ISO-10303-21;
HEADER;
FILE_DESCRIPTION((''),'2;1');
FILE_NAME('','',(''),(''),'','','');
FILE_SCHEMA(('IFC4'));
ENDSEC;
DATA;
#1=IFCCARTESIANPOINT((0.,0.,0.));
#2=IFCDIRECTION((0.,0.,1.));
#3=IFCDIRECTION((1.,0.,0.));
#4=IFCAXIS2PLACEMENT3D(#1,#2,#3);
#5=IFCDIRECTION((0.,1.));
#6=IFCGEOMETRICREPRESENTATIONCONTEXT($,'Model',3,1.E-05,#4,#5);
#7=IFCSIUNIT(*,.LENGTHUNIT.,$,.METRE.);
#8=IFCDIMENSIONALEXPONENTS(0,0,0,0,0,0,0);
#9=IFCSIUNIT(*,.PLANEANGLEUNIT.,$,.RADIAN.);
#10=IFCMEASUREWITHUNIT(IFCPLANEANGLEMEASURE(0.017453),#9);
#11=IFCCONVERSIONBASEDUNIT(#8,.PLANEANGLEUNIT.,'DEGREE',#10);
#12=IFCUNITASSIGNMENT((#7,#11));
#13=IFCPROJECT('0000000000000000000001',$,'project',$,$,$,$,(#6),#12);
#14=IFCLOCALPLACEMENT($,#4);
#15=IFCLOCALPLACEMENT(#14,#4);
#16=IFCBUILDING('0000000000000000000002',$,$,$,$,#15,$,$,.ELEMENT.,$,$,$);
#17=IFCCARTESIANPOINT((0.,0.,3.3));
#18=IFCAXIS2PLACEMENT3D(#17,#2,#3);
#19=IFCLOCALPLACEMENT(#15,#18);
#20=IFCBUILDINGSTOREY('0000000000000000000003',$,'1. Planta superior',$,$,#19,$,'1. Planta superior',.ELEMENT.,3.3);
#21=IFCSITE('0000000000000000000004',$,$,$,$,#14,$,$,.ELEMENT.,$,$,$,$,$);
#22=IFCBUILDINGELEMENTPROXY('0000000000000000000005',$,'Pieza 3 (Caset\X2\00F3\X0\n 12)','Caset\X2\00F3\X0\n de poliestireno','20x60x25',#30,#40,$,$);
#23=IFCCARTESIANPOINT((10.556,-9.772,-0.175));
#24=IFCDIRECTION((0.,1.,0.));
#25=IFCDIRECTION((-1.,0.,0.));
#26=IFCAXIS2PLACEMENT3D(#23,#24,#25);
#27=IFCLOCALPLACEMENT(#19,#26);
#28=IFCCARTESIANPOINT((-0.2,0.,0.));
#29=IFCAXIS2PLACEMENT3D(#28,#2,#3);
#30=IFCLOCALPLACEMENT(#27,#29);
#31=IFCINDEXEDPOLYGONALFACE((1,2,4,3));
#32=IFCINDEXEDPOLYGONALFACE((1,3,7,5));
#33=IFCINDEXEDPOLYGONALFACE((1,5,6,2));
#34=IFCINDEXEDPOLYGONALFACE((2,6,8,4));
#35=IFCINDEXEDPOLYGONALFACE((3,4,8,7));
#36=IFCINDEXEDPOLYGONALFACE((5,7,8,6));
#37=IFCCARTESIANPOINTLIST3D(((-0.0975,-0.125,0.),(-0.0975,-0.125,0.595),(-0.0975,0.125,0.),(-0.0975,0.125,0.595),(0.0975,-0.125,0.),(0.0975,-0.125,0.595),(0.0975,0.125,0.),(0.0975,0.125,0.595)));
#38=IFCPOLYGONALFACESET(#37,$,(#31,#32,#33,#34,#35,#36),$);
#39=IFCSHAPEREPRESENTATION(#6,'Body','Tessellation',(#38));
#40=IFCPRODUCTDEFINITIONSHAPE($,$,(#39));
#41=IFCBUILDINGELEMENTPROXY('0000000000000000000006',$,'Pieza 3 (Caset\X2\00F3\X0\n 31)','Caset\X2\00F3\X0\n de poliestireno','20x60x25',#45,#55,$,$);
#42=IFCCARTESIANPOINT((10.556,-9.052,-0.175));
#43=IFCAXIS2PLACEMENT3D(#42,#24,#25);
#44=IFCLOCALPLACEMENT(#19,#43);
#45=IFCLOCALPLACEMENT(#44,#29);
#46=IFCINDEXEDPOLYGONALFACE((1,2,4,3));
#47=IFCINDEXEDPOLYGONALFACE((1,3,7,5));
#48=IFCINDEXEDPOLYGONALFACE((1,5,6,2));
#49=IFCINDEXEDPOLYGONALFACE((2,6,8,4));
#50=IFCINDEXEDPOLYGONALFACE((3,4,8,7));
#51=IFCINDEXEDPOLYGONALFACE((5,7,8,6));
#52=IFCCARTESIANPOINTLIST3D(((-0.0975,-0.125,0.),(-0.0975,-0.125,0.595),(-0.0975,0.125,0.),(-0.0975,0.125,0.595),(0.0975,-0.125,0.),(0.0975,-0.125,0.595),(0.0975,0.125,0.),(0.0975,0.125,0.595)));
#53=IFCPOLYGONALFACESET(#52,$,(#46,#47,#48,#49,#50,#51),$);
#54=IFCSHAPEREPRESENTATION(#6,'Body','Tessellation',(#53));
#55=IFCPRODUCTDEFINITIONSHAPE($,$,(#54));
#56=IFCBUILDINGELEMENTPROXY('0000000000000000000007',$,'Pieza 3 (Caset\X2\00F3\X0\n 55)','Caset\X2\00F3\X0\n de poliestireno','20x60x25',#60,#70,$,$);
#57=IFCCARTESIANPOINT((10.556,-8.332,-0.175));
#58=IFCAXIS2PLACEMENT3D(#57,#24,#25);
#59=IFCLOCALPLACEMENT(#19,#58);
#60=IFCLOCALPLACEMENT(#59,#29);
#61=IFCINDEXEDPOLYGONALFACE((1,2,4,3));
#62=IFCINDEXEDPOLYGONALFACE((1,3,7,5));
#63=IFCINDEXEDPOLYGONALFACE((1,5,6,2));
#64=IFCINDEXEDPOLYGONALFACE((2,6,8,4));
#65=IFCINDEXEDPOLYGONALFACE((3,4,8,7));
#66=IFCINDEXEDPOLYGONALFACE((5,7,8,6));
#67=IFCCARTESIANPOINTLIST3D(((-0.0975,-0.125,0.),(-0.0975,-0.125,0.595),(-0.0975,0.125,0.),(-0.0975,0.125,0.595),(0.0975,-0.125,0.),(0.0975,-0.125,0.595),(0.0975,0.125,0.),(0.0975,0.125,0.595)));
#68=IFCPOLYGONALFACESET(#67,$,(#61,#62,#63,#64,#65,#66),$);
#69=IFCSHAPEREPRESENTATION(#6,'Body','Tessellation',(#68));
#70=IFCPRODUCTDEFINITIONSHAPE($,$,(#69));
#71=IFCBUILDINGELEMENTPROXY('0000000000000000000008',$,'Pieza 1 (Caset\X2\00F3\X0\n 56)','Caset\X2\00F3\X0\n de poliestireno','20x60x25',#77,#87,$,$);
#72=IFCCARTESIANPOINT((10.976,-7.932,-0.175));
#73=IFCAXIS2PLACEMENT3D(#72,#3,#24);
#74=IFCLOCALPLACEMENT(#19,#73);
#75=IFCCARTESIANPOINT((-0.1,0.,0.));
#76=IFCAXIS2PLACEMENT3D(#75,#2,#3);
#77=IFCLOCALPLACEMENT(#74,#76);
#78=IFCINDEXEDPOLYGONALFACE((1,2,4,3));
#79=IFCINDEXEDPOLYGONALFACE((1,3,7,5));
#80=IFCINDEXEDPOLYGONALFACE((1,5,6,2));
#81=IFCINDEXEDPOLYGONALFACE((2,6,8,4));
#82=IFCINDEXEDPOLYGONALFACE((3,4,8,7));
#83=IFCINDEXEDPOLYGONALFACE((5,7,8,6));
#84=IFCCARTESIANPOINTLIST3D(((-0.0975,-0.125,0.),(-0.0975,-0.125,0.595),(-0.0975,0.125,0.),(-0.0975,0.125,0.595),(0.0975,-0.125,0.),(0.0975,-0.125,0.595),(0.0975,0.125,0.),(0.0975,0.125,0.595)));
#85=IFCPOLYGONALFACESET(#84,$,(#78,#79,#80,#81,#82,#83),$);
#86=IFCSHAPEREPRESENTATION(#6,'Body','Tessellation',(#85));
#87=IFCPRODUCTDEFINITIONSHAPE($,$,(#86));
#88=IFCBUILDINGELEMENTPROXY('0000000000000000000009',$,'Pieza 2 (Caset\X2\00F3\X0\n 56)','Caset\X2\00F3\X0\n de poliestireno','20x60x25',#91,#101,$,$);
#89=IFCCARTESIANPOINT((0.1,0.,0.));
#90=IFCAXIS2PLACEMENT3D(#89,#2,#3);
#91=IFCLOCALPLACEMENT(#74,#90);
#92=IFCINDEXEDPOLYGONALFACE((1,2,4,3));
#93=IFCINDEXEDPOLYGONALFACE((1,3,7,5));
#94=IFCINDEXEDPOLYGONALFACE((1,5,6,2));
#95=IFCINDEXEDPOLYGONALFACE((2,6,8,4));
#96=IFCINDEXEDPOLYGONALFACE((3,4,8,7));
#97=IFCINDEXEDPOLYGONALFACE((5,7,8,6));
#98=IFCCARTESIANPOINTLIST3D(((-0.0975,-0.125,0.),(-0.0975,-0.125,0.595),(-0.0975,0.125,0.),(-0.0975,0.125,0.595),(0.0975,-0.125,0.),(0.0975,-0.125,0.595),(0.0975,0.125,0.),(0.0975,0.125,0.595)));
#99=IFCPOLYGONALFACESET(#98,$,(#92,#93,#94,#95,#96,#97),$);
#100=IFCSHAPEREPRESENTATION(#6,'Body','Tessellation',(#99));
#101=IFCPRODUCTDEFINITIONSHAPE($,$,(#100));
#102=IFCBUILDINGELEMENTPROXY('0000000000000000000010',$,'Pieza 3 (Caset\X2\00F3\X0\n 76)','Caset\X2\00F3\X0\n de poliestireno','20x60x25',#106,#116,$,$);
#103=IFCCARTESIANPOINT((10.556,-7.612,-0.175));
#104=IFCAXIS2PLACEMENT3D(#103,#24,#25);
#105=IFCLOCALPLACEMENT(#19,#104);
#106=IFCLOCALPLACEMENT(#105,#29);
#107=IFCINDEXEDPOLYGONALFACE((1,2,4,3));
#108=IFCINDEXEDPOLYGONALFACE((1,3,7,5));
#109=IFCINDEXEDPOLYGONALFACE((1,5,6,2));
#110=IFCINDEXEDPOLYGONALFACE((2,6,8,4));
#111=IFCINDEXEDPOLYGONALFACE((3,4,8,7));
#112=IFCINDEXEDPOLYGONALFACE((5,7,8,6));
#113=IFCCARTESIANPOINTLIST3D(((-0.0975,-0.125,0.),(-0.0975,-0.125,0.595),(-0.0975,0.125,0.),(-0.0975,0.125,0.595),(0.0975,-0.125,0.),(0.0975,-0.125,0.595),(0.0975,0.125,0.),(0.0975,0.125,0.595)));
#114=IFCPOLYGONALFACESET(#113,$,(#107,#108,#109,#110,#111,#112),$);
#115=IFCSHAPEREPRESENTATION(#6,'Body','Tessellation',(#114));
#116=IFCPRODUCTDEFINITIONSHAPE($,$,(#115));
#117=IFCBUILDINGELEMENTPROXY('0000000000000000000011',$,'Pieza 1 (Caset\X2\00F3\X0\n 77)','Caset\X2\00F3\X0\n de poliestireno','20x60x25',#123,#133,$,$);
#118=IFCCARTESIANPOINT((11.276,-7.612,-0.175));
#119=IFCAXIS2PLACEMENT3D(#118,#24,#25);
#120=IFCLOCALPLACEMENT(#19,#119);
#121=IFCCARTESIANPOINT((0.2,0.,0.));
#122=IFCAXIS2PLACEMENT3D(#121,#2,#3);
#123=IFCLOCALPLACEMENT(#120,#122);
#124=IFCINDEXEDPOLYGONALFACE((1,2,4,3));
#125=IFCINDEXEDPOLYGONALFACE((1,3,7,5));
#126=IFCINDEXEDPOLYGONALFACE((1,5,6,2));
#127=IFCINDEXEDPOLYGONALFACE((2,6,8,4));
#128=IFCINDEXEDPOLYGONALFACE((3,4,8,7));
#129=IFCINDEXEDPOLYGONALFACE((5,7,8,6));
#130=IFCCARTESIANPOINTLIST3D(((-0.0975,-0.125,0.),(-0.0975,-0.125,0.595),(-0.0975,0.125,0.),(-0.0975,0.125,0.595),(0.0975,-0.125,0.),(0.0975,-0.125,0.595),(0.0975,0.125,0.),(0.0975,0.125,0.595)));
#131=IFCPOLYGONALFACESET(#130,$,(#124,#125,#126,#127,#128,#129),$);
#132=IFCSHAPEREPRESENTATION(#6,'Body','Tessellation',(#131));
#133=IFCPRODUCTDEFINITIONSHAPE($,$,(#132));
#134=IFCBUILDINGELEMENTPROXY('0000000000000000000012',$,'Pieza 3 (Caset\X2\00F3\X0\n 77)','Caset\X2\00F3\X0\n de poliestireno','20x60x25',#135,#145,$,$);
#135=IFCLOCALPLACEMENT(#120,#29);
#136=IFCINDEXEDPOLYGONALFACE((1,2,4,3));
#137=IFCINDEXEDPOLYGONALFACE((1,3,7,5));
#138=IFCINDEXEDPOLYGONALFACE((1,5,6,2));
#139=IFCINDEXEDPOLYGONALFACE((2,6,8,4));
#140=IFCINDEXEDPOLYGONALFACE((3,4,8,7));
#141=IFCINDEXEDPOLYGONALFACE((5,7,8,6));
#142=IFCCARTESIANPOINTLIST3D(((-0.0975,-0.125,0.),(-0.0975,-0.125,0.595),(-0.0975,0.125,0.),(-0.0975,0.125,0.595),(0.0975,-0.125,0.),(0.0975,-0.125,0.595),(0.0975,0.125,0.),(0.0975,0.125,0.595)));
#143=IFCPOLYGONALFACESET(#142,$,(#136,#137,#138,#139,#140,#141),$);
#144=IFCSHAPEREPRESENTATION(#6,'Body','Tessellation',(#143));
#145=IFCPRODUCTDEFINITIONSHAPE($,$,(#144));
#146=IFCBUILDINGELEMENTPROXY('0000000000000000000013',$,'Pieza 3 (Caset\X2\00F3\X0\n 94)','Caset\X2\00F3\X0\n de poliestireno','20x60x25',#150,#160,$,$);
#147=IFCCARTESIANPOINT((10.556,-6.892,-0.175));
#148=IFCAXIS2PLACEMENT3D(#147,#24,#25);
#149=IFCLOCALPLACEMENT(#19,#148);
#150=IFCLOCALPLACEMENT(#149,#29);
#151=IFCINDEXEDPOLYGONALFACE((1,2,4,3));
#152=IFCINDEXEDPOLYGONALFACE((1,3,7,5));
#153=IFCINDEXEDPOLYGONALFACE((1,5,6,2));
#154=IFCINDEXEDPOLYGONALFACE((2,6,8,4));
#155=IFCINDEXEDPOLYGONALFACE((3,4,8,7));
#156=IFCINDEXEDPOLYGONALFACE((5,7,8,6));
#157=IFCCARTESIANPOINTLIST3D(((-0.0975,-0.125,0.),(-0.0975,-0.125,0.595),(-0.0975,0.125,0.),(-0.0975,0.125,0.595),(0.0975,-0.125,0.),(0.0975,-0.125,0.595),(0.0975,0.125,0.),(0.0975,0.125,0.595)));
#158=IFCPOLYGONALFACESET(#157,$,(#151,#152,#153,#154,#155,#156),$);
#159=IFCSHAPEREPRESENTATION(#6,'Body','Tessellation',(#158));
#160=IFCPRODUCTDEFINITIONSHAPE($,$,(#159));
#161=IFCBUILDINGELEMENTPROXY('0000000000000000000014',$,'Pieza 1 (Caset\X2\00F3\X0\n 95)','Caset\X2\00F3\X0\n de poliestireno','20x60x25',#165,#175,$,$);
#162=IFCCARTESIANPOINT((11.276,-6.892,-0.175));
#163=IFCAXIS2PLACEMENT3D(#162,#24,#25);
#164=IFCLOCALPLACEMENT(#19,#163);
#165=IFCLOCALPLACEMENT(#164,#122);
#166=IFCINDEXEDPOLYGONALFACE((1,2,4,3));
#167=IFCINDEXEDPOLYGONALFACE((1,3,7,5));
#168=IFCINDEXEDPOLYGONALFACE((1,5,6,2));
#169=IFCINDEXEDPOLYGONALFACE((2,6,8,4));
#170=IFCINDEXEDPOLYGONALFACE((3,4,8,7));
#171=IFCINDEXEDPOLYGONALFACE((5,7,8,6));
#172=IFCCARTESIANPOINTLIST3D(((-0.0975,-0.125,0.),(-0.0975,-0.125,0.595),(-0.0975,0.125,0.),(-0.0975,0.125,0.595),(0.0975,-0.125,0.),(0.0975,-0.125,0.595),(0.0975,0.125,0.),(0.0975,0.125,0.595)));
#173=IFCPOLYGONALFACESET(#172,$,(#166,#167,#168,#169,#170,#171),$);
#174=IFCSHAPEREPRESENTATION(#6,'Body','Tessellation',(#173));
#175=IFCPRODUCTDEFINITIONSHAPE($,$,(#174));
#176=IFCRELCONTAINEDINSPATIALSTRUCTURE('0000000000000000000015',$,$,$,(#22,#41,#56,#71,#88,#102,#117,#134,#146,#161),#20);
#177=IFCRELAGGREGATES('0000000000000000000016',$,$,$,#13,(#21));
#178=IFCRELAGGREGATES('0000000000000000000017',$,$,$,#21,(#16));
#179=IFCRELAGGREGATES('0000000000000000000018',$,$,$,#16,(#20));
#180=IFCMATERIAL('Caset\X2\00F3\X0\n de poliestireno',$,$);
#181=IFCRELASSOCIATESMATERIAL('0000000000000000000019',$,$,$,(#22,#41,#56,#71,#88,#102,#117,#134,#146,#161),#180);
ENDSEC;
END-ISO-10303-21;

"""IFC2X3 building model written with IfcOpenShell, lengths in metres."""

from ifc_helpers import new_model, entity, si_unit, converted_unit, direction, frame, origin_with_axes, origin_2d_with_axis, place, context, project, spatial, rectangle, extrude, source, transform, mapped, material, element, save


model = new_model("IFC2X3")

# Units and contexts
model_context = context("Model", 3, precision=1e-05, world=origin_with_axes(), true_north=direction((0.0, 1.0)))
ifc_project = project(units=[si_unit("LENGTHUNIT", "METRE"), converted_unit("PLANEANGLEUNIT", "DEGREE", entity("IfcPlaneAngleMeasure", 0.017453), si_unit("PLANEANGLEUNIT", "RADIAN"), dimensions=[0, 0, 0, 0, 0, 0, 0])], contexts=[model_context])

# Site, building, storey
site_placement = place(None, origin_with_axes())
site = spatial("IfcSite", under=ifc_project, at=site_placement, CompositionType="ELEMENT")
building_placement = place(site_placement, origin_with_axes())
building = spatial("IfcBuilding", under=site, at=building_placement, CompositionType="ELEMENT")
storey_placement = place(building_placement, frame((0.0, 0.0, 3.3), z_axis=(0.0, 0.0, 1.0), x_axis=(1.0, 0.0, 0.0)))
storey = spatial("IfcBuildingStorey", under=building, at=storey_placement, Name="1. Planta superior", LongName="1. Planta superior", CompositionType="ELEMENT", Elevation=3.3)

# Building element proxies
ifc_material_1 = material(Name="Casetón de poliestireno")
shared_shape = source(origin_with_axes(), model_context, "Body", "SweptSolid", [
    extrude(rectangle(XDim=0.195, YDim=0.25, at=origin_2d_with_axis()), origin_with_axes(), (0.0, 0.0, 1.0), 0.595),
])
placement_1 = place(storey_placement, frame((10.556, -9.772, -0.175), z_axis=(0.0, 1.0, 0.0), x_axis=(-1.0, 0.0, 0.0)))
for number, where, z_axis, x_axis, name in (
    (1, (-0.2, 0.0, 0.0), (0.0, 0.0, 1.0), (1.0, 0.0, 0.0), "Pieza 3 (Casetón 12)"),
):
    element("IfcBuildingElementProxy", number, at=place(placement_1, frame(where, z_axis=z_axis, x_axis=x_axis)), inside=storey, material=ifc_material_1, Name=name, Description="Casetón de poliestireno", ObjectType="20x60x25", context=model_context, shape_type="MappedRepresentation", body=[
        mapped(shared_shape, transform((0.0, 0.0, 0.0), x_axis=(1.0, 0.0, 0.0), y_axis=(0.0, 1.0, 0.0), z_axis=(0.0, 0.0, 1.0))),
    ])
placement_2 = place(storey_placement, frame((10.556, -9.052, -0.175), z_axis=(0.0, 1.0, 0.0), x_axis=(-1.0, 0.0, 0.0)))
for number, where, z_axis, x_axis, name in (
    (2, (-0.2, 0.0, 0.0), (0.0, 0.0, 1.0), (1.0, 0.0, 0.0), "Pieza 3 (Casetón 31)"),
):
    element("IfcBuildingElementProxy", number, at=place(placement_2, frame(where, z_axis=z_axis, x_axis=x_axis)), inside=storey, material=ifc_material_1, Name=name, Description="Casetón de poliestireno", ObjectType="20x60x25", context=model_context, shape_type="MappedRepresentation", body=[
        mapped(shared_shape, transform((0.0, 0.0, 0.0), x_axis=(1.0, 0.0, 0.0), y_axis=(0.0, 1.0, 0.0), z_axis=(0.0, 0.0, 1.0))),
    ])
placement_3 = place(storey_placement, frame((10.556, -8.332, -0.175), z_axis=(0.0, 1.0, 0.0), x_axis=(-1.0, 0.0, 0.0)))
for number, where, z_axis, x_axis, name in (
    (3, (-0.2, 0.0, 0.0), (0.0, 0.0, 1.0), (1.0, 0.0, 0.0), "Pieza 3 (Casetón 55)"),
):
    element("IfcBuildingElementProxy", number, at=place(placement_3, frame(where, z_axis=z_axis, x_axis=x_axis)), inside=storey, material=ifc_material_1, Name=name, Description="Casetón de poliestireno", ObjectType="20x60x25", context=model_context, shape_type="MappedRepresentation", body=[
        mapped(shared_shape, transform((0.0, 0.0, 0.0), x_axis=(1.0, 0.0, 0.0), y_axis=(0.0, 1.0, 0.0), z_axis=(0.0, 0.0, 1.0))),
    ])
placement_4 = place(storey_placement, frame((10.976, -7.932, -0.175), z_axis=(1.0, 0.0, 0.0), x_axis=(0.0, 1.0, 0.0)))
for number, where, z_axis, x_axis, name in (
    (4, (-0.1, 0.0, 0.0), (0.0, 0.0, 1.0), (1.0, 0.0, 0.0), "Pieza 1 (Casetón 56)"),
    (5, (0.1, 0.0, 0.0), (0.0, 0.0, 1.0), (1.0, 0.0, 0.0), "Pieza 2 (Casetón 56)"),
):
    element("IfcBuildingElementProxy", number, at=place(placement_4, frame(where, z_axis=z_axis, x_axis=x_axis)), inside=storey, material=ifc_material_1, Name=name, Description="Casetón de poliestireno", ObjectType="20x60x25", context=model_context, shape_type="MappedRepresentation", body=[
        mapped(shared_shape, transform((0.0, 0.0, 0.0), x_axis=(1.0, 0.0, 0.0), y_axis=(0.0, 1.0, 0.0), z_axis=(0.0, 0.0, 1.0))),
    ])
placement_5 = place(storey_placement, frame((10.556, -7.612, -0.175), z_axis=(0.0, 1.0, 0.0), x_axis=(-1.0, 0.0, 0.0)))
for number, where, z_axis, x_axis, name in (
    (6, (-0.2, 0.0, 0.0), (0.0, 0.0, 1.0), (1.0, 0.0, 0.0), "Pieza 3 (Casetón 76)"),
):
    element("IfcBuildingElementProxy", number, at=place(placement_5, frame(where, z_axis=z_axis, x_axis=x_axis)), inside=storey, material=ifc_material_1, Name=name, Description="Casetón de poliestireno", ObjectType="20x60x25", context=model_context, shape_type="MappedRepresentation", body=[
        mapped(shared_shape, transform((0.0, 0.0, 0.0), x_axis=(1.0, 0.0, 0.0), y_axis=(0.0, 1.0, 0.0), z_axis=(0.0, 0.0, 1.0))),
    ])
placement_6 = place(storey_placement, frame((11.276, -7.612, -0.175), z_axis=(0.0, 1.0, 0.0), x_axis=(-1.0, 0.0, 0.0)))
for number, where, z_axis, x_axis, name in (
    (7, (0.2, 0.0, 0.0), (0.0, 0.0, 1.0), (1.0, 0.0, 0.0), "Pieza 1 (Casetón 77)"),
    (8, (-0.2, 0.0, 0.0), (0.0, 0.0, 1.0), (1.0, 0.0, 0.0), "Pieza 3 (Casetón 77)"),
):
    element("IfcBuildingElementProxy", number, at=place(placement_6, frame(where, z_axis=z_axis, x_axis=x_axis)), inside=storey, material=ifc_material_1, Name=name, Description="Casetón de poliestireno", ObjectType="20x60x25", context=model_context, shape_type="MappedRepresentation", body=[
        mapped(shared_shape, transform((0.0, 0.0, 0.0), x_axis=(1.0, 0.0, 0.0), y_axis=(0.0, 1.0, 0.0), z_axis=(0.0, 0.0, 1.0))),
    ])
placement_7 = place(storey_placement, frame((10.556, -6.892, -0.175), z_axis=(0.0, 1.0, 0.0), x_axis=(-1.0, 0.0, 0.0)))
for number, where, z_axis, x_axis, name in (
    (9, (-0.2, 0.0, 0.0), (0.0, 0.0, 1.0), (1.0, 0.0, 0.0), "Pieza 3 (Casetón 94)"),
):
    element("IfcBuildingElementProxy", number, at=place(placement_7, frame(where, z_axis=z_axis, x_axis=x_axis)), inside=storey, material=ifc_material_1, Name=name, Description="Casetón de poliestireno", ObjectType="20x60x25", context=model_context, shape_type="MappedRepresentation", body=[
        mapped(shared_shape, transform((0.0, 0.0, 0.0), x_axis=(1.0, 0.0, 0.0), y_axis=(0.0, 1.0, 0.0), z_axis=(0.0, 0.0, 1.0))),
    ])
placement_8 = place(storey_placement, frame((11.276, -6.892, -0.175), z_axis=(0.0, 1.0, 0.0), x_axis=(-1.0, 0.0, 0.0)))
for number, where, z_axis, x_axis, name in (
    (10, (0.2, 0.0, 0.0), (0.0, 0.0, 1.0), (1.0, 0.0, 0.0), "Pieza 1 (Casetón 95)"),
):
    element("IfcBuildingElementProxy", number, at=place(placement_8, frame(where, z_axis=z_axis, x_axis=x_axis)), inside=storey, material=ifc_material_1, Name=name, Description="Casetón de poliestireno", ObjectType="20x60x25", context=model_context, shape_type="MappedRepresentation", body=[
        mapped(shared_shape, transform((0.0, 0.0, 0.0), x_axis=(1.0, 0.0, 0.0), y_axis=(0.0, 1.0, 0.0), z_axis=(0.0, 0.0, 1.0))),
    ])

save(model, "model.ifc")
